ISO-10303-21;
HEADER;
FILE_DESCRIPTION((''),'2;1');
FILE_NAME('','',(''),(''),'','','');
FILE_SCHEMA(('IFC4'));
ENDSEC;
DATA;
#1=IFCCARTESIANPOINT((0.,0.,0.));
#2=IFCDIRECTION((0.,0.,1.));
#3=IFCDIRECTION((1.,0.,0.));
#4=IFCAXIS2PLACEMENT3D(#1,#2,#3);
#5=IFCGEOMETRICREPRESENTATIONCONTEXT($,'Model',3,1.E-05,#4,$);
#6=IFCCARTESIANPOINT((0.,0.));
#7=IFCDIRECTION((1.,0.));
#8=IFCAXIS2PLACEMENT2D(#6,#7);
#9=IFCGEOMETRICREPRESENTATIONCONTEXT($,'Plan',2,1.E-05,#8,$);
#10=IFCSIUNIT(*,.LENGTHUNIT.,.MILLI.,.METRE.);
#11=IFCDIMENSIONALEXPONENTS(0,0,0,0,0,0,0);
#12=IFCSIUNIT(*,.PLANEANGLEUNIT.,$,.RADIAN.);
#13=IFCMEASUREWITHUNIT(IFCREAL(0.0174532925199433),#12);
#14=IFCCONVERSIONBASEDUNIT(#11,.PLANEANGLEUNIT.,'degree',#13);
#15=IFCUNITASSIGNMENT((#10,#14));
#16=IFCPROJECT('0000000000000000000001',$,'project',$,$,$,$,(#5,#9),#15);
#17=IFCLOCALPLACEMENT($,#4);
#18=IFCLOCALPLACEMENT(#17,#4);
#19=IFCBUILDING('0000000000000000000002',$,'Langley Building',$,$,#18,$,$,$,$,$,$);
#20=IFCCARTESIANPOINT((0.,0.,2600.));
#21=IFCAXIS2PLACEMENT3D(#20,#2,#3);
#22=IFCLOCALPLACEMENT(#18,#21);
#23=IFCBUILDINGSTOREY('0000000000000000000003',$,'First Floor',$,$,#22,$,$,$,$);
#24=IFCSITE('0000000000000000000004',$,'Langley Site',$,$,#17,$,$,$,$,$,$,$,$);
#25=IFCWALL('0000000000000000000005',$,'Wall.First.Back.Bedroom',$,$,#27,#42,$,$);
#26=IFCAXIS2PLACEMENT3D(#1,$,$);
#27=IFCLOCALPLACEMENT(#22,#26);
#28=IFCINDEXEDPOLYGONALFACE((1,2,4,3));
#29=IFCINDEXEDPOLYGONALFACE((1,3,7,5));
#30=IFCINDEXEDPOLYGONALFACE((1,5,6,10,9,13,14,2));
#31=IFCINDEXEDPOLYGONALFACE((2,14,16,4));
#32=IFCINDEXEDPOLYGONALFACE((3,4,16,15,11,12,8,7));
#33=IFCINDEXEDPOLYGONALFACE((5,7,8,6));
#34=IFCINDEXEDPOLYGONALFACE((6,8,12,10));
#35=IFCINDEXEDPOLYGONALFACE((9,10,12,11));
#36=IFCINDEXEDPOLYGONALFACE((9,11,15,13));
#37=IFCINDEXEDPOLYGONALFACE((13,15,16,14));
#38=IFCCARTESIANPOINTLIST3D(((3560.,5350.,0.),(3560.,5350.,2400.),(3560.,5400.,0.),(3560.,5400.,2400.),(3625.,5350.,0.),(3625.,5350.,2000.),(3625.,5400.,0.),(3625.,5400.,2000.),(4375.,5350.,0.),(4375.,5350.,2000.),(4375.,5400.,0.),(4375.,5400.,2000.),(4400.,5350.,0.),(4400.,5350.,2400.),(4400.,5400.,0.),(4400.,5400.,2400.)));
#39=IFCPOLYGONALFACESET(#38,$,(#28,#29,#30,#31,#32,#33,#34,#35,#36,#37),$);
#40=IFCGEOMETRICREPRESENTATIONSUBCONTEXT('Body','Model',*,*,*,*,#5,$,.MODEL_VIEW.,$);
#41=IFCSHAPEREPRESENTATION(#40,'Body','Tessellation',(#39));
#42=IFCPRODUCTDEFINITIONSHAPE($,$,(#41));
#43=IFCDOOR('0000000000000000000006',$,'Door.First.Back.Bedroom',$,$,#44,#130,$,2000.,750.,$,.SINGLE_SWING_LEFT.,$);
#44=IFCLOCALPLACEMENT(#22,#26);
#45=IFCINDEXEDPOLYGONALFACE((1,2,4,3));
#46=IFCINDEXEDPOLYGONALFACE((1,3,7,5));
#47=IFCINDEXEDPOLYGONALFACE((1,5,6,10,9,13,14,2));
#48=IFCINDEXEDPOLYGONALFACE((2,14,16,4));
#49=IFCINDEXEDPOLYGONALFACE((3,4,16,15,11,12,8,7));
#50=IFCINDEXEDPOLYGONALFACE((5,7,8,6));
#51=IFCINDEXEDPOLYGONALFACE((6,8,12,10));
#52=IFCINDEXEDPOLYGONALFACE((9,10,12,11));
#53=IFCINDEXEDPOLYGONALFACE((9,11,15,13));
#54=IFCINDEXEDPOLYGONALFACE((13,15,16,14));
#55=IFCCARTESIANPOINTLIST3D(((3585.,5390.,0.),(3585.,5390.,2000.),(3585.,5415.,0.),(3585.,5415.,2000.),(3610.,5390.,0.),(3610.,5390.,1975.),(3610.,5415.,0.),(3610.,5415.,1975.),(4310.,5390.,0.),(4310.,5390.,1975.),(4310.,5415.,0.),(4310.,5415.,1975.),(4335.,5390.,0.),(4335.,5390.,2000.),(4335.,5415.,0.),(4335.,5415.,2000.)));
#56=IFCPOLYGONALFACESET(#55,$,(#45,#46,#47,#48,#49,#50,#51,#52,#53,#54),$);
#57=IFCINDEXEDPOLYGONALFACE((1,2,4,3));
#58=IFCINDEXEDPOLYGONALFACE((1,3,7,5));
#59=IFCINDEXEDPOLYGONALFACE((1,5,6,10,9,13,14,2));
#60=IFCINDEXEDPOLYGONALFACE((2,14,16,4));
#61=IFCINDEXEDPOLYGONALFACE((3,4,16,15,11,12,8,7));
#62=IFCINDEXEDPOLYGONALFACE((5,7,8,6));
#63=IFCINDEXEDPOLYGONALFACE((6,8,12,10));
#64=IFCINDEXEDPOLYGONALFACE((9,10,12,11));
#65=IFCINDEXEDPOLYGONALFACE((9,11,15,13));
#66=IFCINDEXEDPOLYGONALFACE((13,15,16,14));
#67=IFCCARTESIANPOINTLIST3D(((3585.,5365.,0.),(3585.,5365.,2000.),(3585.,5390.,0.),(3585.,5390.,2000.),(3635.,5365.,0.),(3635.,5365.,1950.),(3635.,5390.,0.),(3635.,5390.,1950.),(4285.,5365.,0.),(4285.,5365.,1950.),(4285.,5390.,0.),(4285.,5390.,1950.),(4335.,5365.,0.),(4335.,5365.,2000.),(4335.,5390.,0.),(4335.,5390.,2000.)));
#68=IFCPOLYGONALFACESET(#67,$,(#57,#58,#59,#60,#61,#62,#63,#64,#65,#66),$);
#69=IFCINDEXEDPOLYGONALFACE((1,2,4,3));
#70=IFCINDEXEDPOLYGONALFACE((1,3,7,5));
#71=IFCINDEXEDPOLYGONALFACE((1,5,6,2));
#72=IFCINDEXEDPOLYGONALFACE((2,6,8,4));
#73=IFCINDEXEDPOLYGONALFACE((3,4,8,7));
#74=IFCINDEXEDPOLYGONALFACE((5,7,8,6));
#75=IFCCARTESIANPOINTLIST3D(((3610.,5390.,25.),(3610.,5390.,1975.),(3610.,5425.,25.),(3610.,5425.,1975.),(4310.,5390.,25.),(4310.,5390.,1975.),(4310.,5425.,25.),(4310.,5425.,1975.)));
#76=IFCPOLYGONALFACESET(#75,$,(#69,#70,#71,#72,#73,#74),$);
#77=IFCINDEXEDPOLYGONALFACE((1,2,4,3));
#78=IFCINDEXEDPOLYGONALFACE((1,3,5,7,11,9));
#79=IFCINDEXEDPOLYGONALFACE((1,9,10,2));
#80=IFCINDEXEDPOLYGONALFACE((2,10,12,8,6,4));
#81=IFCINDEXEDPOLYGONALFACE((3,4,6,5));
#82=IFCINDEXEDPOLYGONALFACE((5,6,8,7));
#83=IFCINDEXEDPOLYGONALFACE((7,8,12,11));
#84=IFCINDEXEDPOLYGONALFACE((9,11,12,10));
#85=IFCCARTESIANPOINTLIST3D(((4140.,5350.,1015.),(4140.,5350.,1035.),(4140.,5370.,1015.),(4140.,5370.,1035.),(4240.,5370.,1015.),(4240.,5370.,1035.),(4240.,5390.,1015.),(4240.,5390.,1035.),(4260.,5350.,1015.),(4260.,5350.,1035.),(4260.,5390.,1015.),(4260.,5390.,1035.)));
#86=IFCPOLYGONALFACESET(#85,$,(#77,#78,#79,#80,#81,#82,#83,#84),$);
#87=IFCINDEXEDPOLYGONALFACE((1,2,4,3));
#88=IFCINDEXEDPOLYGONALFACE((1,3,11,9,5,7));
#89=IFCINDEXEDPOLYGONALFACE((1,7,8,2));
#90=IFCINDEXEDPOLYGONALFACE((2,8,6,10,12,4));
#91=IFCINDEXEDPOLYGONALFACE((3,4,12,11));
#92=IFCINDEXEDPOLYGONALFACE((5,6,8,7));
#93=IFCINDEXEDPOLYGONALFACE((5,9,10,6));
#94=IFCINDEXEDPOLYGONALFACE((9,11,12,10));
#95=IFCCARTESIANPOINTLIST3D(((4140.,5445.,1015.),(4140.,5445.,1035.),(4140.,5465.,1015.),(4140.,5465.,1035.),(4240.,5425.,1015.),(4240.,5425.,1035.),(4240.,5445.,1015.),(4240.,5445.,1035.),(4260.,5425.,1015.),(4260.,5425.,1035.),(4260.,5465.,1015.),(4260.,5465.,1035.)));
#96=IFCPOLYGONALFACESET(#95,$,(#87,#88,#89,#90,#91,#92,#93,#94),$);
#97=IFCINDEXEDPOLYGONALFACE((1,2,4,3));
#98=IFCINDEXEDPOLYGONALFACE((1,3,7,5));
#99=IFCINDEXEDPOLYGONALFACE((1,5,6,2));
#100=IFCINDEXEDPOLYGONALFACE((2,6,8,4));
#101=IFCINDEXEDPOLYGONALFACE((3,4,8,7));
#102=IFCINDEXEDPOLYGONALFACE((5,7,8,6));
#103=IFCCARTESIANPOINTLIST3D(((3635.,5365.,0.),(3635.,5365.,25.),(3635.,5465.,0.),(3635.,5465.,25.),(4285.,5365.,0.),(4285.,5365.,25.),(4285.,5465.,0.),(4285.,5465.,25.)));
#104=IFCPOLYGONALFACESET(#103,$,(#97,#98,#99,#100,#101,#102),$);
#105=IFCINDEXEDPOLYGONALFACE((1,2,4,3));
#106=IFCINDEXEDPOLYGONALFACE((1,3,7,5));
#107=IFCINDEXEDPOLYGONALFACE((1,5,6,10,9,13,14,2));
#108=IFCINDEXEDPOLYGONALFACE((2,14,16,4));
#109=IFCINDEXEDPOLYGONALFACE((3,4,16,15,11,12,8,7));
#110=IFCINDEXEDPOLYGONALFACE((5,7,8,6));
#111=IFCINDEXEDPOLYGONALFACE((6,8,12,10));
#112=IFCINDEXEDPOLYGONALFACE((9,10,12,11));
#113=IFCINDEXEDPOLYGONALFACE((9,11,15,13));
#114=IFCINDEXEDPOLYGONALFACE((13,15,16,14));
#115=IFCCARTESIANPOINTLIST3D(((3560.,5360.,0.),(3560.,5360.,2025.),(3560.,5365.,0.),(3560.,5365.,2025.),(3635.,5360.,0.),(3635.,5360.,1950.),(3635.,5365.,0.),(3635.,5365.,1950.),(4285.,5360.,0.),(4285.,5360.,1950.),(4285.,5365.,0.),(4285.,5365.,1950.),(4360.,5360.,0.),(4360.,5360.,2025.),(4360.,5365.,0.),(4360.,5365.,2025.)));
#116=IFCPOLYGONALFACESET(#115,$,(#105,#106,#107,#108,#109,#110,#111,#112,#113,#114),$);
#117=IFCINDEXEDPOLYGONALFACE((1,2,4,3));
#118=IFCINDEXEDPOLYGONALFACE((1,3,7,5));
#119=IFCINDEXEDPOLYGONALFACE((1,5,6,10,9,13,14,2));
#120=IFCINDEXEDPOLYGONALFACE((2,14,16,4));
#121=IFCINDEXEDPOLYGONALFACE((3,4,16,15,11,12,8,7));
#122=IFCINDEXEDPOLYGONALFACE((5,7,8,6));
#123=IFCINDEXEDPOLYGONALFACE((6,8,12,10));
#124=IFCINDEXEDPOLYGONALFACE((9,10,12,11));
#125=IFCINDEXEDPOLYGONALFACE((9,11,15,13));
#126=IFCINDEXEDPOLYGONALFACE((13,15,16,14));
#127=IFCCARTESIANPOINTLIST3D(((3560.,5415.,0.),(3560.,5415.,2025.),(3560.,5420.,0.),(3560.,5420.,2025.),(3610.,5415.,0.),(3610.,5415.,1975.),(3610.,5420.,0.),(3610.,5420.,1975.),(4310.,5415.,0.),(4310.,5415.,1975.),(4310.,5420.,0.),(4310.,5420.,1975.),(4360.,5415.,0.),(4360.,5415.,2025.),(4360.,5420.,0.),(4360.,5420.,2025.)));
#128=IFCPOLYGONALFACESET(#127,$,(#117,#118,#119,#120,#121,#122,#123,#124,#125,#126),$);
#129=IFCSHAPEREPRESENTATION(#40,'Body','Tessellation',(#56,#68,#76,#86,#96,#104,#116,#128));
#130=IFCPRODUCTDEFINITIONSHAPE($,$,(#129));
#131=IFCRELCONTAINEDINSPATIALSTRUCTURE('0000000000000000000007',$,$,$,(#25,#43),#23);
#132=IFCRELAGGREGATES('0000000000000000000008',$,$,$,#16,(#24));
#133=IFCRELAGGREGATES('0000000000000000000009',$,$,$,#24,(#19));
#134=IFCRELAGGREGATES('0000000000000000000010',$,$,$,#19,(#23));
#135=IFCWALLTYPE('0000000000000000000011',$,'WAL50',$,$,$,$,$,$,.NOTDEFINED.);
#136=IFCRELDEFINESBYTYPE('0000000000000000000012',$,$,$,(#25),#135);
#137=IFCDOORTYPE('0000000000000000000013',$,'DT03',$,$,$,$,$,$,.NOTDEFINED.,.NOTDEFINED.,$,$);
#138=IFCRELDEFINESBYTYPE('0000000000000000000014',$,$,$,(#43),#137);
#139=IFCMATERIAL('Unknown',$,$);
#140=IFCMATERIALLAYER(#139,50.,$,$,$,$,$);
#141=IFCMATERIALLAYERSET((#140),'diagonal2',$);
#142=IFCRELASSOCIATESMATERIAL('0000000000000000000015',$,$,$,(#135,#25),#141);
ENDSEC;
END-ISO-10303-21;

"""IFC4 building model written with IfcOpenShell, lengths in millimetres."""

from ifc_helpers import new_model, entity, si_unit, converted_unit, frame, origin_with_axes, origin_2d_with_axis, place, context, subcontext, project, spatial, line, indexed_curve, outline, extrude, shape, source, transform, mapped, material, layer, layer_set, layer_usage, type_object, type_shapes, element, fill, save


model = new_model("IFC4")

# Units and contexts
model_context = context("Model", 3, precision=1e-05, world=origin_with_axes())
plan_context = context("Plan", 2, precision=1e-05, world=origin_2d_with_axis())
body_context_1 = subcontext(model_context, "Body", "Model", "MODEL_VIEW")
body_context_2 = subcontext(plan_context, "Body", "Plan", "PLAN_VIEW")
ifc_project = project(units=[si_unit("LENGTHUNIT", "METRE", prefix="MILLI"), converted_unit("PLANEANGLEUNIT", "degree", entity("IfcReal", 0.0174532925199433), si_unit("PLANEANGLEUNIT", "RADIAN"), dimensions=[0, 0, 0, 0, 0, 0, 0])], contexts=[model_context, plan_context])

# Site, building, storey
site_placement = place(None, origin_with_axes())
site = spatial("IfcSite", under=ifc_project, at=site_placement, Name="Langley Site")
building_placement = place(site_placement, origin_with_axes())
building = spatial("IfcBuilding", under=site, at=building_placement, Name="Langley Building")
storey_placement = place(building_placement, frame((0.0, 0.0, 2600.0), z_axis=(0.0, 0.0, 1.0), x_axis=(1.0, 0.0, 0.0)))
storey = spatial("IfcBuildingStorey", under=building, at=storey_placement, Name="First Floor")

# Shared definitions
ifc_material = material(Name="Unknown")
ifc_layer_1 = layer(ifc_material, 50.0)
ifc_layer_set_1 = layer_set([ifc_layer_1], Name="diagonal2")
wall_type_1 = type_object("IfcWallType", Name="WAL50", PredefinedType="NOTDEFINED", material=ifc_layer_set_1)

# Wall, opening, door
ifc_layer_usage_1 = layer_usage(ifc_layer_set_1, "AXIS2", "POSITIVE", 0.0)
wall_1_placement = place(storey_placement, frame((4400.0, 5400.0, 0.0), z_axis=(0.0, 0.0, 1.0), x_axis=(-1.0, 0.0, 0.0)))
wall_1 = element("IfcWall", 1, at=wall_1_placement, inside=storey, type_object=wall_type_1, material=ifc_layer_usage_1, Name="Wall.First.Back.Bedroom", context=body_context_1, shape_type="SweptSolid", body=[
    extrude(outline(indexed_curve([(0.0, 0.0), (0.0, 50.0), (840.0, 50.0), (840.0, 0.0)], segments=[line(1, 2, 3, 4, 1)])), origin_with_axes(), (0.0, 0.0, 1.0), 2400.0),
])
shared_shape_1 = source(origin_with_axes(), body_context_1, "Body", "SweptSolid", [
    extrude(outline(indexed_curve([(0.0, 0.0), (750.0, 0.0), (750.0, 2000.0), (0.0, 2000.0)], segments=[line(1, 2, 3, 4, 1)])), frame((0.0, -600.0, 0.0), z_axis=(0.0, -1.0, 0.0), x_axis=(1.0, 0.0, 0.0)), (0.0, 0.0, -1.0), 1200.0),
])
opening_1_placement = place(wall_1_placement, frame((25.0, 0.0, 0.0), z_axis=(0.0, 0.0, 1.0), x_axis=(1.0, 0.0, 0.0)))
opening_1 = element("IfcOpeningElement", 2, at=opening_1_placement, cuts=wall_1, PredefinedType="OPENING", context=body_context_1, shape_type="MappedRepresentation", body=[
    mapped(shared_shape_1, transform((0.0, 0.0, 0.0), x_axis=(1.0, 0.0, 0.0), y_axis=(0.0, 1.0, 0.0), z_axis=(0.0, 0.0, 1.0), scale=1.0)),
])
door_type_1 = type_object("IfcDoorType", Name="DT03", OperationType="NOTDEFINED", PredefinedType="NOTDEFINED")
shared_shape_2 = source(origin_with_axes(), body_context_1, "Body", "SweptSolid", [
    extrude(outline(indexed_curve([(0.0, 0.0), (0.0, 2000.0), (750.0, 2000.0), (750.0, 0.0), (725.0, 0.0), (725.0, 1975.0), (25.0, 1975.0), (25.0, 0.0)], segments=[line(1, 2, 3, 4, 5, 6, 7, 8, 1)])), frame((0.0, 25.0, 0.0), z_axis=(0.0, -1.0, 0.0), x_axis=(1.0, 0.0, 0.0)), (0.0, 0.0, -1.0), 25.0),
    extrude(outline(indexed_curve([(0.0, 0.0), (0.0, 2000.0), (750.0, 2000.0), (750.0, 0.0), (700.0, 0.0), (700.0, 1950.0), (50.0, 1950.0), (50.0, 0.0)], segments=[line(1, 2, 3, 4, 5, 6, 7, 8, 1)])), frame((0.0, 0.0, 0.0), z_axis=(0.0, -1.0, 0.0), x_axis=(1.0, 0.0, 0.0)), (0.0, 0.0, -1.0), 25.0),
    extrude(outline(indexed_curve([(0.0, 0.0), (700.0, 0.0), (700.0, 35.0), (0.0, 35.0)], segments=[line(1, 2, 3, 4, 1)])), frame((25.0, 25.0, 25.0), z_axis=(0.0, 0.0, 1.0), x_axis=(1.0, 0.0, 0.0)), (0.0, 0.0, 1.0), 1950.0),
    extrude(outline(indexed_curve([(0.0, 0.0), (0.0, -40.0), (-120.0, -40.0), (-120.0, -20.0), (-20.0, -20.0), (-20.0, 0.0)], segments=[line(1, 2, 3, 4, 5, 6, 1)])), frame((675.0, 25.0, 1015.0), z_axis=(0.0, 0.0, 1.0), x_axis=(1.0, 0.0, 0.0)), (0.0, 0.0, 1.0), 20.0),
    extrude(outline(indexed_curve([(0.0, 0.0), (0.0, 40.0), (-120.0, 40.0), (-120.0, 20.0), (-20.0, 20.0), (-20.0, 0.0)], segments=[line(1, 2, 3, 4, 5, 6, 1)])), frame((675.0, 60.0, 1015.0), z_axis=(0.0, 0.0, 1.0), x_axis=(1.0, 0.0, 0.0)), (0.0, 0.0, 1.0), 20.0),
    extrude(outline(indexed_curve([(0.0, 0.0), (650.0, 0.0), (650.0, 100.0), (0.0, 100.0)], segments=[line(1, 2, 3, 4, 1)])), frame((50.0, 0.0, 0.0), z_axis=(0.0, 0.0, 1.0), x_axis=(1.0, 0.0, 0.0)), (0.0, 0.0, 1.0), 25.0),
    extrude(outline(indexed_curve([(0.0, 0.0), (0.0, 2025.0), (800.0, 2025.0), (800.0, 0.0), (725.0, 0.0), (725.0, 1950.0), (75.0, 1950.0), (75.0, 0.0)], segments=[line(1, 2, 3, 4, 5, 6, 7, 8, 1)])), frame((-25.0, -5.0, 0.0), z_axis=(0.0, -1.0, 0.0), x_axis=(1.0, 0.0, 0.0)), (0.0, 0.0, -1.0), 5.0),
    extrude(outline(indexed_curve([(0.0, 0.0), (0.0, 2025.0), (800.0, 2025.0), (800.0, 0.0), (750.0, 0.0), (750.0, 1975.0), (50.0, 1975.0), (50.0, 0.0)], segments=[line(1, 2, 3, 4, 5, 6, 7, 8, 1)])), frame((-25.0, 50.0, 0.0), z_axis=(0.0, -1.0, 0.0), x_axis=(1.0, 0.0, 0.0)), (0.0, 0.0, -1.0), 5.0),
])
shared_shape_3 = source(origin_with_axes(), body_context_2, "Body", "Curve2D", [
    entity("IfcIndexedPolyCurve", entity("IfcCartesianPointList2D", [[0.0, 0.0], [0.0, 50.0], [25.0, 50.0], [25.0, 25.0], [50.0, 25.0], [50.0, 0.0]]), [entity("IfcLineIndex", [1, 2, 3, 4, 5, 6, 1])]),
    entity("IfcIndexedPolyCurve", entity("IfcCartesianPointList2D", [[750.0, 0.0], [750.0, 50.0], [725.0, 50.0], [725.0, 25.0], [700.0, 25.0], [700.0, 0.0]]), [entity("IfcLineIndex", [1, 2, 3, 4, 5, 6, 1])]),
    entity("IfcTrimmedCurve", entity("IfcEllipse", entity("IfcAxis2Placement2D", entity("IfcCartesianPoint", [60.0, 50.0]), entity("IfcDirection", [1.0, 0.0])), 665.0, 700.0), [entity("IfcCartesianPoint", [725.0, 50.0])], [entity("IfcCartesianPoint", [60.0, 750.0])], True, "CARTESIAN"),
    entity("IfcIndexedPolyCurve", entity("IfcCartesianPointList2D", [[25.0, 50.0], [60.0, 50.0], [60.0, 750.0], [25.0, 750.0]]), [entity("IfcLineIndex", [1, 2, 3, 4, 1])]),
])
type_shapes(door_type_1, [shared_shape_2, shared_shape_3])
door_1_placement = place(opening_1_placement, frame((790.0, 35.0, 0.0), z_axis=(0.0, 0.0, 1.0), x_axis=(-1.0, 0.0, 0.0)))
door_1 = element("IfcDoor", 3, at=door_1_placement, inside=storey, type_object=door_type_1, Name="Door.First.Back.Bedroom", OperationType="SINGLE_SWING_LEFT", OverallHeight=2000.0, OverallWidth=750.0, shapes=[
    shape(body_context_1, "Body", "MappedRepresentation", [mapped(shared_shape_2, transform((0.0, 0.0, 0.0), x_axis=(1.0, 0.0, 0.0), y_axis=(0.0, 1.0, 0.0), z_axis=(0.0, 0.0, 1.0), scale=1.0))]),
    shape(body_context_2, "Body", "MappedRepresentation", [mapped(shared_shape_3, transform((0.0, 0.0, 0.0), x_axis=(1.0, 0.0, 0.0), y_axis=(0.0, 1.0, 0.0), z_axis=(0.0, 0.0, 1.0), scale=1.0))]),
])
fill(opening_1, door_1)

save(model, "model.ifc")
